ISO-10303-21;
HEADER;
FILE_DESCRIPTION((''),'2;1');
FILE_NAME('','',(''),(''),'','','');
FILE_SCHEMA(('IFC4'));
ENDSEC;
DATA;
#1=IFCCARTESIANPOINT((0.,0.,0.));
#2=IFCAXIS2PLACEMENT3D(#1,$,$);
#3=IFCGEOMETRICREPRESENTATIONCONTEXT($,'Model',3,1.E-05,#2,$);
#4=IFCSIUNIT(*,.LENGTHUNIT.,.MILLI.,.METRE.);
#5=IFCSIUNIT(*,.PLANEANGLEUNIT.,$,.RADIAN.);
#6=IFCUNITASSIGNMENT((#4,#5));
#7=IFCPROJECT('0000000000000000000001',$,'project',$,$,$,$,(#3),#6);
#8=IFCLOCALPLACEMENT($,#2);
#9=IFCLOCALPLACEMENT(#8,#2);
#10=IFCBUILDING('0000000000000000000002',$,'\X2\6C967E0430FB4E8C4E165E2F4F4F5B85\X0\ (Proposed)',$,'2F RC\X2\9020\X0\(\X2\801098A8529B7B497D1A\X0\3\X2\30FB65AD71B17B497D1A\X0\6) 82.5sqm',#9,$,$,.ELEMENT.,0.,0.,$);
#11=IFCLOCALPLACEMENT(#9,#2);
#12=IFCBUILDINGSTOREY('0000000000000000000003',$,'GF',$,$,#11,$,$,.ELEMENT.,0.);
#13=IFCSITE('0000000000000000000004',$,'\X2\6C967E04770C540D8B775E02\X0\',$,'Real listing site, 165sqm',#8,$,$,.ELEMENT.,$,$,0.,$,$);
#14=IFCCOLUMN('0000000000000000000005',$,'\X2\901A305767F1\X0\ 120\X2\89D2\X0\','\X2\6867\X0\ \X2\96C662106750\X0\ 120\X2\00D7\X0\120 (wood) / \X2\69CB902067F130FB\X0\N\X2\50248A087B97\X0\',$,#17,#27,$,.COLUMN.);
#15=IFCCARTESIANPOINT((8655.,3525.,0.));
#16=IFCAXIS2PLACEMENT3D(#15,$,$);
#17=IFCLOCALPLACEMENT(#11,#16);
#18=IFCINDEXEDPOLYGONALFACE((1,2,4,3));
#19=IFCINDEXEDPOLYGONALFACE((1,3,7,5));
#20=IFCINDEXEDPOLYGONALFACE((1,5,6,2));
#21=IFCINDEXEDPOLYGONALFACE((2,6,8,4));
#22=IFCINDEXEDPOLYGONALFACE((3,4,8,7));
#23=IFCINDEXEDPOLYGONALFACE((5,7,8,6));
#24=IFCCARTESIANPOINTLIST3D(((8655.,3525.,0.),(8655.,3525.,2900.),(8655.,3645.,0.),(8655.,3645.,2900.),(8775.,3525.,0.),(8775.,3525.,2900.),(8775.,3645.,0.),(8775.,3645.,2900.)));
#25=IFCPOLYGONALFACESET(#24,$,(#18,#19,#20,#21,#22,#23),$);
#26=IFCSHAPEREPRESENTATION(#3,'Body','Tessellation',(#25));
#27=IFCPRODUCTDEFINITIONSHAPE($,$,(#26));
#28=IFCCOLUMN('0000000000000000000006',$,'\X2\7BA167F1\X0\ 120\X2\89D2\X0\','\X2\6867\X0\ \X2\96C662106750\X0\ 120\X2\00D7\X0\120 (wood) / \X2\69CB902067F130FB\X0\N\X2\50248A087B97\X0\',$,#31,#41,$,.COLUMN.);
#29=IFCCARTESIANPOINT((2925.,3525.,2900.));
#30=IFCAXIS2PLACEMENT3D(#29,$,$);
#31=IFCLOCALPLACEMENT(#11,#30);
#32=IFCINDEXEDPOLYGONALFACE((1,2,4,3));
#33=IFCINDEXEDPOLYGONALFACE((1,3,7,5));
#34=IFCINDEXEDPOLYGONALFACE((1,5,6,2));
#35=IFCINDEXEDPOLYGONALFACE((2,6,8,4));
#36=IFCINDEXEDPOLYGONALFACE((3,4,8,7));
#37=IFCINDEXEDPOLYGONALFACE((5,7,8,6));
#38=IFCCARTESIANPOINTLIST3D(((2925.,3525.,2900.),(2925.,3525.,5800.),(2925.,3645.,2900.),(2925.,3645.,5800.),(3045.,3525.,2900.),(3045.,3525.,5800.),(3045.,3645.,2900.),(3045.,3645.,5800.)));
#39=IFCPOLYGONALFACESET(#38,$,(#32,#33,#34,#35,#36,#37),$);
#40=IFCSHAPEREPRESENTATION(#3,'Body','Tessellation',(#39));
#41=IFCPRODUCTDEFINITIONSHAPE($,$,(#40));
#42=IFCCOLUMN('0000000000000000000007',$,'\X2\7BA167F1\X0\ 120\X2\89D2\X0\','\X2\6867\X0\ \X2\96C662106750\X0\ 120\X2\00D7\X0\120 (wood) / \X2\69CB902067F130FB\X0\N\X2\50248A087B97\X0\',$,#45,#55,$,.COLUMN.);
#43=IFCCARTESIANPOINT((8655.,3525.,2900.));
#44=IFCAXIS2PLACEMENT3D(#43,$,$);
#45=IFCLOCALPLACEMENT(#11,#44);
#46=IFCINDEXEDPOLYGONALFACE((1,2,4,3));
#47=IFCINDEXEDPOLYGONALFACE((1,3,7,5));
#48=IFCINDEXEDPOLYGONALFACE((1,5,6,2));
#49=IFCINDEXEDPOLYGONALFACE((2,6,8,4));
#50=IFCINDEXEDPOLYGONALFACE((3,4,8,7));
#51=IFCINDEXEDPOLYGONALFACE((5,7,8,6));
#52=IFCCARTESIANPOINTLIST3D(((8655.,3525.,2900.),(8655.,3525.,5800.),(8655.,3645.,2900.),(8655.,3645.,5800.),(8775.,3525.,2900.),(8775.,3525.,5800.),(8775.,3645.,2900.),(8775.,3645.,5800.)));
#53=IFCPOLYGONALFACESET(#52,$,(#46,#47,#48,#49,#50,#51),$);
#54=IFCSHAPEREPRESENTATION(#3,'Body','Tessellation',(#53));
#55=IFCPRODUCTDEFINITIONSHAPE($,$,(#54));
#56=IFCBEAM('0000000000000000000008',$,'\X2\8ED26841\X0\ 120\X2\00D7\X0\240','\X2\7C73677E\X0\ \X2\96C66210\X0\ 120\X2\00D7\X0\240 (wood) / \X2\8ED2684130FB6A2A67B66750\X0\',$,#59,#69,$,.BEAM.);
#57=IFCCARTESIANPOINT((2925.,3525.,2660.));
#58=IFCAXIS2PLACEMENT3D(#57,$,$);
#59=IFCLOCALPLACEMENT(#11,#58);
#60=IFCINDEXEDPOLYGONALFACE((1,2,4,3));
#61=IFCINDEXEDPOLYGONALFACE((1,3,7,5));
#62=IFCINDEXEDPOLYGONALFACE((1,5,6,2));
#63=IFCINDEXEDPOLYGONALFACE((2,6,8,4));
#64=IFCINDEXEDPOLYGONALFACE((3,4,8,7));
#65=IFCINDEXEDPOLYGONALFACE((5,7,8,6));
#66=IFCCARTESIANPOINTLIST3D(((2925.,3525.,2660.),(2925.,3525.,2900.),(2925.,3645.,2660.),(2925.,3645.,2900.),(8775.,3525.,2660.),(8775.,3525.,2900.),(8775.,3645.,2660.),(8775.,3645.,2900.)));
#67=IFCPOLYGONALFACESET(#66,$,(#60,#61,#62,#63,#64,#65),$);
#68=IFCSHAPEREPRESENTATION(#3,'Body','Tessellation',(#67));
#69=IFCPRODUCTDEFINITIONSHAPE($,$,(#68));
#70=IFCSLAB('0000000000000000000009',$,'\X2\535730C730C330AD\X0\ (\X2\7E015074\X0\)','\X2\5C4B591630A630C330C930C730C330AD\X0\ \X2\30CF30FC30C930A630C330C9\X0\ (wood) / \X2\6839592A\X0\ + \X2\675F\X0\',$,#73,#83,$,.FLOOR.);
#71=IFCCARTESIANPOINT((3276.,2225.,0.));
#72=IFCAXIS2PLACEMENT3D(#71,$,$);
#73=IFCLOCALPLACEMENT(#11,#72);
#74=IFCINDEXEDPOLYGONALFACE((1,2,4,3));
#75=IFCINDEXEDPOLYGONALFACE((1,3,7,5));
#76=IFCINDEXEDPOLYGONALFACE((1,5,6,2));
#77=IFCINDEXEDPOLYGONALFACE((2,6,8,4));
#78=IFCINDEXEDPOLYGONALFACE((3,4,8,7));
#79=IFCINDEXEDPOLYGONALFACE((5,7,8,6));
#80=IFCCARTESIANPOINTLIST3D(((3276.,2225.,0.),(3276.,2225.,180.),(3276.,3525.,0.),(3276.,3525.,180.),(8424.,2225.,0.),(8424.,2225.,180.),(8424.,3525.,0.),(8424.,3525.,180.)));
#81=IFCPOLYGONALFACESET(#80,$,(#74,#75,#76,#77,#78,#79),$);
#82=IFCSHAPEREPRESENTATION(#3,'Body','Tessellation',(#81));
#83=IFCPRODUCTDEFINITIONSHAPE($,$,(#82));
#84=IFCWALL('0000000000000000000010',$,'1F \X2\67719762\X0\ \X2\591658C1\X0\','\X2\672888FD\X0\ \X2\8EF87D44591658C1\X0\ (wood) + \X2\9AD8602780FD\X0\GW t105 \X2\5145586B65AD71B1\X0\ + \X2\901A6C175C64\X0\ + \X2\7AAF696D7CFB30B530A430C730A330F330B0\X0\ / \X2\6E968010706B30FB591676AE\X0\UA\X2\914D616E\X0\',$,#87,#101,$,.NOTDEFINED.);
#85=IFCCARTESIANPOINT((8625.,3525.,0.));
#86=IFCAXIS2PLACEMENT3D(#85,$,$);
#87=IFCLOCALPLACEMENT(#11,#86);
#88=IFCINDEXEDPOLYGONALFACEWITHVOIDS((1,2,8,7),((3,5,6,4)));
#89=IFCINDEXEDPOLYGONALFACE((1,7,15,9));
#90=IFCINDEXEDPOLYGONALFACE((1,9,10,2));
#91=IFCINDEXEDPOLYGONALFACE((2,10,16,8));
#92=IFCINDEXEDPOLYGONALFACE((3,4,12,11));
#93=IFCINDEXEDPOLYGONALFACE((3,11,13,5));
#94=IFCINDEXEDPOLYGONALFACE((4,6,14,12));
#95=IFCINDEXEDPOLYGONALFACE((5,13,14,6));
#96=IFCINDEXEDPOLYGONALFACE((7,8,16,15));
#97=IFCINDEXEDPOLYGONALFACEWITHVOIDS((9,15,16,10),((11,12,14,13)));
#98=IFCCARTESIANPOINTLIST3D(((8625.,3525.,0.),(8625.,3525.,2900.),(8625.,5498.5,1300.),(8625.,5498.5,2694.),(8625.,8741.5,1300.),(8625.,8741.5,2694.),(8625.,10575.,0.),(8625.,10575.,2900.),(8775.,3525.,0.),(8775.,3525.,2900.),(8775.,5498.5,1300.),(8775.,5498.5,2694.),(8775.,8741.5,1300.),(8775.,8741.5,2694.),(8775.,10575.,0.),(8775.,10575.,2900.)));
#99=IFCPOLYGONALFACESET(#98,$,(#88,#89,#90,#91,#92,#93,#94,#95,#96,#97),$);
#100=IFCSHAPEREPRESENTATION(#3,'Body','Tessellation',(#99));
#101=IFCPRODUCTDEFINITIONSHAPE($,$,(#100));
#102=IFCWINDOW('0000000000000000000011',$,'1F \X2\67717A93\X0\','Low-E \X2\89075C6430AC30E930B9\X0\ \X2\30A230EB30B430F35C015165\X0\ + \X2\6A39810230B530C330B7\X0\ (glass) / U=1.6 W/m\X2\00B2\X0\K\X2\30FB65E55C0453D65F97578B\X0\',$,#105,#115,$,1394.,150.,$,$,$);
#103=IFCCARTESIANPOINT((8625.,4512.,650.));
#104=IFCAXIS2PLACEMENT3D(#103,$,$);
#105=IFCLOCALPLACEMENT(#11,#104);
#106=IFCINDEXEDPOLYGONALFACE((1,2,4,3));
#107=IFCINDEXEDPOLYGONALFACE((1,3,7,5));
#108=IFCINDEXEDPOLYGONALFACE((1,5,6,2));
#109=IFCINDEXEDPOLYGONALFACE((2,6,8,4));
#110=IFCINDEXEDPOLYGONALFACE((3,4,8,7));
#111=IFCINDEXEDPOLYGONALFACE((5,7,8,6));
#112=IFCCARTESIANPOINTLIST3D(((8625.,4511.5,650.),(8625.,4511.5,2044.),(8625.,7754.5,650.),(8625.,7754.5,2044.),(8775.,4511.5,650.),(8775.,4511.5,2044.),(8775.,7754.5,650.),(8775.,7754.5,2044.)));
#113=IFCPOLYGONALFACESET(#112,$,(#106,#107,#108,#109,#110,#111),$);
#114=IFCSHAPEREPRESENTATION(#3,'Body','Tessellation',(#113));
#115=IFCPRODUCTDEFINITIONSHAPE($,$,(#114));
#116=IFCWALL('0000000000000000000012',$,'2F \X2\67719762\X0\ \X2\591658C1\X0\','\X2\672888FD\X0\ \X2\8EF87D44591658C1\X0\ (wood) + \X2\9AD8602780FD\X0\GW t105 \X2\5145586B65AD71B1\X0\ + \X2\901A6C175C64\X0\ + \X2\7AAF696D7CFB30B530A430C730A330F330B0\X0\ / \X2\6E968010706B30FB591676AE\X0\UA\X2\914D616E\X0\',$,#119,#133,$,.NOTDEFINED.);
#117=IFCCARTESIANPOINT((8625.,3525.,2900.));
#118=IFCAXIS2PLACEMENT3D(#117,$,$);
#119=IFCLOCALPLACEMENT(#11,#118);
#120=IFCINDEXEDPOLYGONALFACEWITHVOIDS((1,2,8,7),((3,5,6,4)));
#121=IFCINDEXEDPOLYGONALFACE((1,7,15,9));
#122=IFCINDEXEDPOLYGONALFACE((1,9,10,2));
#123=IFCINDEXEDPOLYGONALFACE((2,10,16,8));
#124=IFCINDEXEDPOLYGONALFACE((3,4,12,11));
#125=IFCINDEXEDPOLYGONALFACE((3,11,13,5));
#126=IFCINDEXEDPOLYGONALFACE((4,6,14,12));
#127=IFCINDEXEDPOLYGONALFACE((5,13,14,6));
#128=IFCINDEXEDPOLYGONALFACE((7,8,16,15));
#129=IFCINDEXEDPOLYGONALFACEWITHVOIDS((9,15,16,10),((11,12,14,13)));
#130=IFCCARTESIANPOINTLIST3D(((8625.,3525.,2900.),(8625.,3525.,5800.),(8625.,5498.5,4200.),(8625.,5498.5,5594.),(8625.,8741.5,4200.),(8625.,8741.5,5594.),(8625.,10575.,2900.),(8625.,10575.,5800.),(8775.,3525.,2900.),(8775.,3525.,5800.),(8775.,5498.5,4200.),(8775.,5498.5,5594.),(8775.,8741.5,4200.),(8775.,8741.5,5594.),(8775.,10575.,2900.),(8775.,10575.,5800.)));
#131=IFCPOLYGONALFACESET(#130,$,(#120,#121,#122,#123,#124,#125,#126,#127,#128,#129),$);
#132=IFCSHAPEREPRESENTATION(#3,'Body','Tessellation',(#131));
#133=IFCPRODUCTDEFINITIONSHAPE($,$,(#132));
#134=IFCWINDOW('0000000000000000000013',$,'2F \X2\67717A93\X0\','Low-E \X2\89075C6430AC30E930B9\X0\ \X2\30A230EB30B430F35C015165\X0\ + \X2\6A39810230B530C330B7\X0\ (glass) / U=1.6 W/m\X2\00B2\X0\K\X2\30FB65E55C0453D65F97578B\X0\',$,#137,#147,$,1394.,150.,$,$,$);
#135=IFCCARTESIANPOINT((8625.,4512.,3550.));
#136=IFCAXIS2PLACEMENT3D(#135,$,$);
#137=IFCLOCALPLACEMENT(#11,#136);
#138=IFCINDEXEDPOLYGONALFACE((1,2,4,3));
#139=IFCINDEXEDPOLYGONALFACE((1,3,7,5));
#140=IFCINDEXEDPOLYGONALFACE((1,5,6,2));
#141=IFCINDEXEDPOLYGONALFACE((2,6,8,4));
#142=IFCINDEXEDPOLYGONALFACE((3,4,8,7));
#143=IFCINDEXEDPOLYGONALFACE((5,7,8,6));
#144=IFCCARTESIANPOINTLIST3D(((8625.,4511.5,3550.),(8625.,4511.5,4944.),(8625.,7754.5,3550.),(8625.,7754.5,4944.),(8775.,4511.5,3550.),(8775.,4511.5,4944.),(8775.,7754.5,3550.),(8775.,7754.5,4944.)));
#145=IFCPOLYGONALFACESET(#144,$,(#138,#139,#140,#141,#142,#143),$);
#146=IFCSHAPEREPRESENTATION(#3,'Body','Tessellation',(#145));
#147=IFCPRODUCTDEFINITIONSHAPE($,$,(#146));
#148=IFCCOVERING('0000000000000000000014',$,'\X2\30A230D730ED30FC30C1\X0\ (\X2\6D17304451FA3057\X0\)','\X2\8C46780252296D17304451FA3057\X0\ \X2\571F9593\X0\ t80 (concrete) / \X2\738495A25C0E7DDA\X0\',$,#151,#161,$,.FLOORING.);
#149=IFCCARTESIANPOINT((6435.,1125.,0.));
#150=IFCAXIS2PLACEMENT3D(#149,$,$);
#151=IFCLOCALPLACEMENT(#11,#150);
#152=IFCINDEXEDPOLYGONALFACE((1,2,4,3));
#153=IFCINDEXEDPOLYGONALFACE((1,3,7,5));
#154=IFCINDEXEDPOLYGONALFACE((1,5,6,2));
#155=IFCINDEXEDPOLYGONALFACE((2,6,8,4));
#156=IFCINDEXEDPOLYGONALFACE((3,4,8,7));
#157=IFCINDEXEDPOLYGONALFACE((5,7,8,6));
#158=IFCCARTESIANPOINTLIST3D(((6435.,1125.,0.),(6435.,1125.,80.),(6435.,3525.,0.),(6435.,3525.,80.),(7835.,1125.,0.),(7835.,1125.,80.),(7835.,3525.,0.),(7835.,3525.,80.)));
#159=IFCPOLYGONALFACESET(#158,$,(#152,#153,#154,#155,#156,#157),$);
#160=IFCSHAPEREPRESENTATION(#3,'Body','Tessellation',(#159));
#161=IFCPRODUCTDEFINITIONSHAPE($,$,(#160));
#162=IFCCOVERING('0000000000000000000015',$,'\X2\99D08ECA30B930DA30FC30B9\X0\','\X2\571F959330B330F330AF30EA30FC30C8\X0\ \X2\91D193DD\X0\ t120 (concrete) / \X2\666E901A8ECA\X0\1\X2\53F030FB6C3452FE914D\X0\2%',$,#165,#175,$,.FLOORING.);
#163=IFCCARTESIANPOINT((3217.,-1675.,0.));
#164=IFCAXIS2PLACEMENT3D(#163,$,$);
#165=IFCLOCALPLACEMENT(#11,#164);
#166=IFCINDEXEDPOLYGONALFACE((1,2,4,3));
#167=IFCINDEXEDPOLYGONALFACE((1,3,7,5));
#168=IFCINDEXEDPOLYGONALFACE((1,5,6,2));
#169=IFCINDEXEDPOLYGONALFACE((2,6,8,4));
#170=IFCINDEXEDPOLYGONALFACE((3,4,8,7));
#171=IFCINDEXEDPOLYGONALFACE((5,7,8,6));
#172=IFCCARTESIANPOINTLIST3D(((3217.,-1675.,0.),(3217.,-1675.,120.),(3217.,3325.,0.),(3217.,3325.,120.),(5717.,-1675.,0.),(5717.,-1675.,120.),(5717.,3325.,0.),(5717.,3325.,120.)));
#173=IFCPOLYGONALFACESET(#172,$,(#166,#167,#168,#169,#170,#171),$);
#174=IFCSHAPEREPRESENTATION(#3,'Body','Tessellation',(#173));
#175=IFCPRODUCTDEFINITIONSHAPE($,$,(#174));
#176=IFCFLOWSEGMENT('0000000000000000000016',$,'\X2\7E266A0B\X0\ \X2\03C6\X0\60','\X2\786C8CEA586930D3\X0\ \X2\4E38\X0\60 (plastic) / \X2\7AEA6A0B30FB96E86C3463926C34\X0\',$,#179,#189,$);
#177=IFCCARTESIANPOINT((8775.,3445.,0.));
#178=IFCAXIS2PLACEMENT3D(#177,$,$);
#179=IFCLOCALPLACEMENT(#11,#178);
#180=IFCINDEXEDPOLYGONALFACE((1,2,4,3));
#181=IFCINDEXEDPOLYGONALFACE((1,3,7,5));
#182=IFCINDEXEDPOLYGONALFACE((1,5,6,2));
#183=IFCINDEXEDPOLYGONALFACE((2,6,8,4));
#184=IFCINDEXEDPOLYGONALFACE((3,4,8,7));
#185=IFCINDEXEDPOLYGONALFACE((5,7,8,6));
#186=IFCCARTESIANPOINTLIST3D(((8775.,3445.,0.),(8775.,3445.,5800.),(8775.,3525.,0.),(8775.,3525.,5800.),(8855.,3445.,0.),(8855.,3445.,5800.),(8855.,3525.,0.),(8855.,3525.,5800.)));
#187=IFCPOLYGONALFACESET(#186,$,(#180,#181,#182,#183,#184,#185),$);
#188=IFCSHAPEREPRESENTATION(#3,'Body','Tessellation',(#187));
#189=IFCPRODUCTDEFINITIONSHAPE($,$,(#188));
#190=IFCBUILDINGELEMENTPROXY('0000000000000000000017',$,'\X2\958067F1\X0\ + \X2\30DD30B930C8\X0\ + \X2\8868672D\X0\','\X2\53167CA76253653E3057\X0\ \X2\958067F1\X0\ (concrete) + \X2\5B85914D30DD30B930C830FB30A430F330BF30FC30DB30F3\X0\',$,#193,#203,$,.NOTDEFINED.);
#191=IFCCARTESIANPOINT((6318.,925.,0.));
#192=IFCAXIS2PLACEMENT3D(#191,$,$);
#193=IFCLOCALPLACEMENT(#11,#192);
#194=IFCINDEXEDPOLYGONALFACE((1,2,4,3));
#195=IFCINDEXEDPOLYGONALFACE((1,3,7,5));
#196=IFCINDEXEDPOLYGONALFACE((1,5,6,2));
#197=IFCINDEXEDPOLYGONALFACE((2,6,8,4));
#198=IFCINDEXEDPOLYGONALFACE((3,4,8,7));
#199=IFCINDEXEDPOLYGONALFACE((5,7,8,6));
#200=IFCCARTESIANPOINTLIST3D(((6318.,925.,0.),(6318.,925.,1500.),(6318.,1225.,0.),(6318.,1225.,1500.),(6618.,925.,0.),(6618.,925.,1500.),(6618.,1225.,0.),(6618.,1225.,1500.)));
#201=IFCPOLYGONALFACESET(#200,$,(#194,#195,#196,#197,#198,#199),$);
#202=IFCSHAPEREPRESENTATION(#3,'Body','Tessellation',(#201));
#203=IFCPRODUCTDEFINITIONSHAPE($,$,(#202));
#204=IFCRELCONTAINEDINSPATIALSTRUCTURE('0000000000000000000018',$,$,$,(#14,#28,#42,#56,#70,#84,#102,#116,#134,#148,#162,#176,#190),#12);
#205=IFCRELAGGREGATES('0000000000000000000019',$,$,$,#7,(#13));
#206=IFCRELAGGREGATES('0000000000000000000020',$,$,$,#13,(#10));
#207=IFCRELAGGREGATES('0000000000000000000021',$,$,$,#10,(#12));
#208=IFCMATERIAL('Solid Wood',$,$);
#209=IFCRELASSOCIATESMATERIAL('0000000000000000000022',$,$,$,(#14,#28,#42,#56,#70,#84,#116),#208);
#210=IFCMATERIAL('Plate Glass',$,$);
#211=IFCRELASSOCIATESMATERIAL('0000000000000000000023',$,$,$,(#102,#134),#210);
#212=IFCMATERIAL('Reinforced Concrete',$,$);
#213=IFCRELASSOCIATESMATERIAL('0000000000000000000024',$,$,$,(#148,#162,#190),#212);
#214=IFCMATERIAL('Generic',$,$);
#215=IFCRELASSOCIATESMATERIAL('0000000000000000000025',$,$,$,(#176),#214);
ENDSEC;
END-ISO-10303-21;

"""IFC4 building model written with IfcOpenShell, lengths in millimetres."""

from ifc_helpers import new_model, si_unit, frame, frame_2d, origin, place, context, project, spatial, rectangle, extrude, material, element, fill, save


model = new_model("IFC4")

# Units and contexts
model_context = context("Model", 3, precision=1e-05, world=origin())
ifc_project = project(units=[si_unit("LENGTHUNIT", "METRE", prefix="MILLI"), si_unit("PLANEANGLEUNIT", "RADIAN")], contexts=[model_context])

# Site, building, storey
site_placement = place(None, origin())
site = spatial("IfcSite", under=ifc_project, at=site_placement, Name="沖縄県名護市", ObjectType="Real listing site, 165sqm", CompositionType="ELEMENT", RefElevation=0.0)
building_placement = place(site_placement, origin())
building = spatial("IfcBuilding", under=site, at=building_placement, Name="沖縄・二世帯住宅 (Proposed)", ObjectType="2F RC造(耐風力等級3・断熱等級6) 82.5sqm", CompositionType="ELEMENT", ElevationOfRefHeight=0.0, ElevationOfTerrain=0.0)
storey_placement = place(building_placement, origin())
storey = spatial("IfcBuildingStorey", under=building, at=storey_placement, Name="GF", CompositionType="ELEMENT", Elevation=0.0)

# Columns
ifc_material_1 = material(Name="Solid Wood")
column_1_placement = place(storey_placement, frame((8655.0, 3525.0, 0.0)))
element("IfcColumn", 1, at=column_1_placement, inside=storey, material=ifc_material_1, Name="通し柱 120角", Description="桧 集成材 120×120 (wood) / 構造柱・N値計算", PredefinedType="COLUMN", context=model_context, shape_type="SweptSolid", body=[
    extrude(rectangle(XDim=120.0, YDim=120.0, at=frame_2d((60.0, 60.0))), frame((8655.0, 3525.0, 0.0)), (0.0, 0.0, 1.0), 2900.0),
])
column_2_placement = place(storey_placement, frame((2925.0, 3525.0, 2900.0)))
element("IfcColumn", 2, at=column_2_placement, inside=storey, material=ifc_material_1, Name="管柱 120角", Description="桧 集成材 120×120 (wood) / 構造柱・N値計算", PredefinedType="COLUMN", context=model_context, shape_type="SweptSolid", body=[
    extrude(rectangle(XDim=120.0, YDim=120.0, at=frame_2d((60.0, 60.0))), frame((2925.0, 3525.0, 2900.0)), (0.0, 0.0, 1.0), 2900.0),
])
column_3_placement = place(storey_placement, frame((8655.0, 3525.0, 2900.0)))
element("IfcColumn", 3, at=column_3_placement, inside=storey, material=ifc_material_1, Name="管柱 120角", Description="桧 集成材 120×120 (wood) / 構造柱・N値計算", PredefinedType="COLUMN", context=model_context, shape_type="SweptSolid", body=[
    extrude(rectangle(XDim=120.0, YDim=120.0, at=frame_2d((60.0, 60.0))), frame((8655.0, 3525.0, 2900.0)), (0.0, 0.0, 1.0), 2900.0),
])

# Beam
beam_1_placement = place(storey_placement, frame((2925.0, 3525.0, 2660.0)))
element("IfcBeam", 4, at=beam_1_placement, inside=storey, material=ifc_material_1, Name="軒桁 120×240", Description="米松 集成 120×240 (wood) / 軒桁・横架材", PredefinedType="BEAM", context=model_context, shape_type="SweptSolid", body=[
    extrude(rectangle(XDim=5850.0, YDim=120.0, at=frame_2d((2925.0, 60.0))), frame((2925.0, 3525.0, 2660.0)), (0.0, 0.0, 1.0), 240.0),
])

# Slab
slab_placement = place(storey_placement, frame((3276.0, 2225.0, 0.0)))
element("IfcSlab", 5, at=slab_placement, inside=storey, material=ifc_material_1, Name="南デッキ (縁側)", Description="屋外ウッドデッキ ハードウッド (wood) / 根太 + 束", PredefinedType="FLOOR", context=model_context, shape_type="SweptSolid", body=[
    extrude(rectangle(XDim=5148.0, YDim=1300.0, at=frame_2d((2574.0, 650.0))), frame((3276.0, 2225.0, 0.0)), (0.0, 0.0, 1.0), 180.0),
])

# Walls, openings, windows
wall_1_placement = place(storey_placement, frame((8625.0, 3525.0, 0.0)))
wall_1 = element("IfcWall", 6, at=wall_1_placement, inside=storey, material=ifc_material_1, Name="1F 東面 外壁", Description="木製 軸組外壁 (wood) + 高性能GW t105 充填断熱 + 通気層 + 窯業系サイディング / 準耐火・外皮UA配慮", PredefinedType="NOTDEFINED", context=model_context, shape_type="SweptSolid", body=[
    extrude(rectangle(XDim=150.0, YDim=7050.0, at=frame_2d((75.0, 3525.0))), frame((8625.0, 3525.0, 0.0)), (0.0, 0.0, 1.0), 2900.0),
])
opening_1_placement = place(storey_placement, frame((8625.0, 4512.0, 650.0)))
opening_1 = element("IfcOpeningElement", 7, at=opening_1_placement, cuts=wall_1, PredefinedType="NOTDEFINED", context=model_context, shape_type="SweptSolid", body=[
    extrude(rectangle(XDim=150.0, YDim=3243.0, at=frame_2d((75.0, 1621.0))), frame((8625.0, 4512.0, 650.0)), (0.0, 0.0, 1.0), 1394.0),
])
ifc_material_2 = material(Name="Plate Glass")
window_1_placement = place(storey_placement, frame((8625.0, 4512.0, 650.0)))
window_1 = element("IfcWindow", 8, at=window_1_placement, inside=storey, material=ifc_material_2, Name="1F 東窓", Description="Low-E 複層ガラス アルゴン封入 + 樹脂サッシ (glass) / U=1.6 W/m²K・日射取得型", OverallHeight=1394.0, OverallWidth=150.0, context=model_context, shape_type="SweptSolid", body=[
    extrude(rectangle(XDim=150.0, YDim=3243.0, at=frame_2d((75.0, 1621.0))), frame((8625.0, 4512.0, 650.0)), (0.0, 0.0, 1.0), 1394.0),
])
fill(opening_1, window_1)
wall_2_placement = place(storey_placement, frame((8625.0, 3525.0, 2900.0)))
wall_2 = element("IfcWall", 9, at=wall_2_placement, inside=storey, material=ifc_material_1, Name="2F 東面 外壁", Description="木製 軸組外壁 (wood) + 高性能GW t105 充填断熱 + 通気層 + 窯業系サイディング / 準耐火・外皮UA配慮", PredefinedType="NOTDEFINED", context=model_context, shape_type="SweptSolid", body=[
    extrude(rectangle(XDim=150.0, YDim=7050.0, at=frame_2d((75.0, 3525.0))), frame((8625.0, 3525.0, 2900.0)), (0.0, 0.0, 1.0), 2900.0),
])
opening_2_placement = place(storey_placement, frame((8625.0, 4512.0, 3550.0)))
opening_2 = element("IfcOpeningElement", 10, at=opening_2_placement, cuts=wall_2, PredefinedType="NOTDEFINED", context=model_context, shape_type="SweptSolid", body=[
    extrude(rectangle(XDim=150.0, YDim=3243.0, at=frame_2d((75.0, 1621.0))), frame((8625.0, 4512.0, 3550.0)), (0.0, 0.0, 1.0), 1394.0),
])
window_2_placement = place(storey_placement, frame((8625.0, 4512.0, 3550.0)))
window_2 = element("IfcWindow", 11, at=window_2_placement, inside=storey, material=ifc_material_2, Name="2F 東窓", Description="Low-E 複層ガラス アルゴン封入 + 樹脂サッシ (glass) / U=1.6 W/m²K・日射取得型", OverallHeight=1394.0, OverallWidth=150.0, context=model_context, shape_type="SweptSolid", body=[
    extrude(rectangle(XDim=150.0, YDim=3243.0, at=frame_2d((75.0, 1621.0))), frame((8625.0, 4512.0, 3550.0)), (0.0, 0.0, 1.0), 1394.0),
])
fill(opening_2, window_2)

# Coverings
ifc_material_3 = material(Name="Reinforced Concrete")
covering_1_placement = place(storey_placement, frame((6435.0, 1125.0, 0.0)))
element("IfcCovering", 12, at=covering_1_placement, inside=storey, material=ifc_material_3, Name="アプローチ (洗い出し)", Description="豆砂利洗い出し 土間 t80 (concrete) / 玄関導線", PredefinedType="FLOORING", context=model_context, shape_type="SweptSolid", body=[
    extrude(rectangle(XDim=1400.0, YDim=2400.0, at=frame_2d((700.0, 1200.0))), frame((6435.0, 1125.0, 0.0)), (0.0, 0.0, 1.0), 80.0),
])
covering_2_placement = place(storey_placement, frame((3217.0, -1675.0, 0.0)))
element("IfcCovering", 13, at=covering_2_placement, inside=storey, material=ifc_material_3, Name="駐車スペース", Description="土間コンクリート 金鏝 t120 (concrete) / 普通車1台・水勾配2%", PredefinedType="FLOORING", context=model_context, shape_type="SweptSolid", body=[
    extrude(rectangle(XDim=2500.0, YDim=5000.0, at=frame_2d((1250.0, 2500.0))), frame((3217.0, -1675.0, 0.0)), (0.0, 0.0, 1.0), 120.0),
])

# Flow segment
ifc_material_4 = material(Name="Generic")
flow_segment_placement = place(storey_placement, frame((8775.0, 3445.0, 0.0)))
element("IfcFlowSegment", 14, at=flow_segment_placement, inside=storey, material=ifc_material_4, Name="縦樋 φ60", Description="硬質塩ビ 丸60 (plastic) / 竪樋・雨水排水", context=model_context, shape_type="SweptSolid", body=[
    extrude(rectangle(XDim=80.0, YDim=80.0, at=frame_2d((40.0, 40.0))), frame((8775.0, 3445.0, 0.0)), (0.0, 0.0, 1.0), 5800.0),
])

# Building element proxy
proxy_placement = place(storey_placement, frame((6318.0, 925.0, 0.0)))
element("IfcBuildingElementProxy", 15, at=proxy_placement, inside=storey, material=ifc_material_3, Name="門柱 + ポスト + 表札", Description="化粧打放し 門柱 (concrete) + 宅配ポスト・インターホン", PredefinedType="NOTDEFINED", context=model_context, shape_type="SweptSolid", body=[
    extrude(rectangle(XDim=300.0, YDim=300.0, at=frame_2d((150.0, 150.0))), frame((6318.0, 925.0, 0.0)), (0.0, 0.0, 1.0), 1500.0),
])

save(model, "model.ifc")
